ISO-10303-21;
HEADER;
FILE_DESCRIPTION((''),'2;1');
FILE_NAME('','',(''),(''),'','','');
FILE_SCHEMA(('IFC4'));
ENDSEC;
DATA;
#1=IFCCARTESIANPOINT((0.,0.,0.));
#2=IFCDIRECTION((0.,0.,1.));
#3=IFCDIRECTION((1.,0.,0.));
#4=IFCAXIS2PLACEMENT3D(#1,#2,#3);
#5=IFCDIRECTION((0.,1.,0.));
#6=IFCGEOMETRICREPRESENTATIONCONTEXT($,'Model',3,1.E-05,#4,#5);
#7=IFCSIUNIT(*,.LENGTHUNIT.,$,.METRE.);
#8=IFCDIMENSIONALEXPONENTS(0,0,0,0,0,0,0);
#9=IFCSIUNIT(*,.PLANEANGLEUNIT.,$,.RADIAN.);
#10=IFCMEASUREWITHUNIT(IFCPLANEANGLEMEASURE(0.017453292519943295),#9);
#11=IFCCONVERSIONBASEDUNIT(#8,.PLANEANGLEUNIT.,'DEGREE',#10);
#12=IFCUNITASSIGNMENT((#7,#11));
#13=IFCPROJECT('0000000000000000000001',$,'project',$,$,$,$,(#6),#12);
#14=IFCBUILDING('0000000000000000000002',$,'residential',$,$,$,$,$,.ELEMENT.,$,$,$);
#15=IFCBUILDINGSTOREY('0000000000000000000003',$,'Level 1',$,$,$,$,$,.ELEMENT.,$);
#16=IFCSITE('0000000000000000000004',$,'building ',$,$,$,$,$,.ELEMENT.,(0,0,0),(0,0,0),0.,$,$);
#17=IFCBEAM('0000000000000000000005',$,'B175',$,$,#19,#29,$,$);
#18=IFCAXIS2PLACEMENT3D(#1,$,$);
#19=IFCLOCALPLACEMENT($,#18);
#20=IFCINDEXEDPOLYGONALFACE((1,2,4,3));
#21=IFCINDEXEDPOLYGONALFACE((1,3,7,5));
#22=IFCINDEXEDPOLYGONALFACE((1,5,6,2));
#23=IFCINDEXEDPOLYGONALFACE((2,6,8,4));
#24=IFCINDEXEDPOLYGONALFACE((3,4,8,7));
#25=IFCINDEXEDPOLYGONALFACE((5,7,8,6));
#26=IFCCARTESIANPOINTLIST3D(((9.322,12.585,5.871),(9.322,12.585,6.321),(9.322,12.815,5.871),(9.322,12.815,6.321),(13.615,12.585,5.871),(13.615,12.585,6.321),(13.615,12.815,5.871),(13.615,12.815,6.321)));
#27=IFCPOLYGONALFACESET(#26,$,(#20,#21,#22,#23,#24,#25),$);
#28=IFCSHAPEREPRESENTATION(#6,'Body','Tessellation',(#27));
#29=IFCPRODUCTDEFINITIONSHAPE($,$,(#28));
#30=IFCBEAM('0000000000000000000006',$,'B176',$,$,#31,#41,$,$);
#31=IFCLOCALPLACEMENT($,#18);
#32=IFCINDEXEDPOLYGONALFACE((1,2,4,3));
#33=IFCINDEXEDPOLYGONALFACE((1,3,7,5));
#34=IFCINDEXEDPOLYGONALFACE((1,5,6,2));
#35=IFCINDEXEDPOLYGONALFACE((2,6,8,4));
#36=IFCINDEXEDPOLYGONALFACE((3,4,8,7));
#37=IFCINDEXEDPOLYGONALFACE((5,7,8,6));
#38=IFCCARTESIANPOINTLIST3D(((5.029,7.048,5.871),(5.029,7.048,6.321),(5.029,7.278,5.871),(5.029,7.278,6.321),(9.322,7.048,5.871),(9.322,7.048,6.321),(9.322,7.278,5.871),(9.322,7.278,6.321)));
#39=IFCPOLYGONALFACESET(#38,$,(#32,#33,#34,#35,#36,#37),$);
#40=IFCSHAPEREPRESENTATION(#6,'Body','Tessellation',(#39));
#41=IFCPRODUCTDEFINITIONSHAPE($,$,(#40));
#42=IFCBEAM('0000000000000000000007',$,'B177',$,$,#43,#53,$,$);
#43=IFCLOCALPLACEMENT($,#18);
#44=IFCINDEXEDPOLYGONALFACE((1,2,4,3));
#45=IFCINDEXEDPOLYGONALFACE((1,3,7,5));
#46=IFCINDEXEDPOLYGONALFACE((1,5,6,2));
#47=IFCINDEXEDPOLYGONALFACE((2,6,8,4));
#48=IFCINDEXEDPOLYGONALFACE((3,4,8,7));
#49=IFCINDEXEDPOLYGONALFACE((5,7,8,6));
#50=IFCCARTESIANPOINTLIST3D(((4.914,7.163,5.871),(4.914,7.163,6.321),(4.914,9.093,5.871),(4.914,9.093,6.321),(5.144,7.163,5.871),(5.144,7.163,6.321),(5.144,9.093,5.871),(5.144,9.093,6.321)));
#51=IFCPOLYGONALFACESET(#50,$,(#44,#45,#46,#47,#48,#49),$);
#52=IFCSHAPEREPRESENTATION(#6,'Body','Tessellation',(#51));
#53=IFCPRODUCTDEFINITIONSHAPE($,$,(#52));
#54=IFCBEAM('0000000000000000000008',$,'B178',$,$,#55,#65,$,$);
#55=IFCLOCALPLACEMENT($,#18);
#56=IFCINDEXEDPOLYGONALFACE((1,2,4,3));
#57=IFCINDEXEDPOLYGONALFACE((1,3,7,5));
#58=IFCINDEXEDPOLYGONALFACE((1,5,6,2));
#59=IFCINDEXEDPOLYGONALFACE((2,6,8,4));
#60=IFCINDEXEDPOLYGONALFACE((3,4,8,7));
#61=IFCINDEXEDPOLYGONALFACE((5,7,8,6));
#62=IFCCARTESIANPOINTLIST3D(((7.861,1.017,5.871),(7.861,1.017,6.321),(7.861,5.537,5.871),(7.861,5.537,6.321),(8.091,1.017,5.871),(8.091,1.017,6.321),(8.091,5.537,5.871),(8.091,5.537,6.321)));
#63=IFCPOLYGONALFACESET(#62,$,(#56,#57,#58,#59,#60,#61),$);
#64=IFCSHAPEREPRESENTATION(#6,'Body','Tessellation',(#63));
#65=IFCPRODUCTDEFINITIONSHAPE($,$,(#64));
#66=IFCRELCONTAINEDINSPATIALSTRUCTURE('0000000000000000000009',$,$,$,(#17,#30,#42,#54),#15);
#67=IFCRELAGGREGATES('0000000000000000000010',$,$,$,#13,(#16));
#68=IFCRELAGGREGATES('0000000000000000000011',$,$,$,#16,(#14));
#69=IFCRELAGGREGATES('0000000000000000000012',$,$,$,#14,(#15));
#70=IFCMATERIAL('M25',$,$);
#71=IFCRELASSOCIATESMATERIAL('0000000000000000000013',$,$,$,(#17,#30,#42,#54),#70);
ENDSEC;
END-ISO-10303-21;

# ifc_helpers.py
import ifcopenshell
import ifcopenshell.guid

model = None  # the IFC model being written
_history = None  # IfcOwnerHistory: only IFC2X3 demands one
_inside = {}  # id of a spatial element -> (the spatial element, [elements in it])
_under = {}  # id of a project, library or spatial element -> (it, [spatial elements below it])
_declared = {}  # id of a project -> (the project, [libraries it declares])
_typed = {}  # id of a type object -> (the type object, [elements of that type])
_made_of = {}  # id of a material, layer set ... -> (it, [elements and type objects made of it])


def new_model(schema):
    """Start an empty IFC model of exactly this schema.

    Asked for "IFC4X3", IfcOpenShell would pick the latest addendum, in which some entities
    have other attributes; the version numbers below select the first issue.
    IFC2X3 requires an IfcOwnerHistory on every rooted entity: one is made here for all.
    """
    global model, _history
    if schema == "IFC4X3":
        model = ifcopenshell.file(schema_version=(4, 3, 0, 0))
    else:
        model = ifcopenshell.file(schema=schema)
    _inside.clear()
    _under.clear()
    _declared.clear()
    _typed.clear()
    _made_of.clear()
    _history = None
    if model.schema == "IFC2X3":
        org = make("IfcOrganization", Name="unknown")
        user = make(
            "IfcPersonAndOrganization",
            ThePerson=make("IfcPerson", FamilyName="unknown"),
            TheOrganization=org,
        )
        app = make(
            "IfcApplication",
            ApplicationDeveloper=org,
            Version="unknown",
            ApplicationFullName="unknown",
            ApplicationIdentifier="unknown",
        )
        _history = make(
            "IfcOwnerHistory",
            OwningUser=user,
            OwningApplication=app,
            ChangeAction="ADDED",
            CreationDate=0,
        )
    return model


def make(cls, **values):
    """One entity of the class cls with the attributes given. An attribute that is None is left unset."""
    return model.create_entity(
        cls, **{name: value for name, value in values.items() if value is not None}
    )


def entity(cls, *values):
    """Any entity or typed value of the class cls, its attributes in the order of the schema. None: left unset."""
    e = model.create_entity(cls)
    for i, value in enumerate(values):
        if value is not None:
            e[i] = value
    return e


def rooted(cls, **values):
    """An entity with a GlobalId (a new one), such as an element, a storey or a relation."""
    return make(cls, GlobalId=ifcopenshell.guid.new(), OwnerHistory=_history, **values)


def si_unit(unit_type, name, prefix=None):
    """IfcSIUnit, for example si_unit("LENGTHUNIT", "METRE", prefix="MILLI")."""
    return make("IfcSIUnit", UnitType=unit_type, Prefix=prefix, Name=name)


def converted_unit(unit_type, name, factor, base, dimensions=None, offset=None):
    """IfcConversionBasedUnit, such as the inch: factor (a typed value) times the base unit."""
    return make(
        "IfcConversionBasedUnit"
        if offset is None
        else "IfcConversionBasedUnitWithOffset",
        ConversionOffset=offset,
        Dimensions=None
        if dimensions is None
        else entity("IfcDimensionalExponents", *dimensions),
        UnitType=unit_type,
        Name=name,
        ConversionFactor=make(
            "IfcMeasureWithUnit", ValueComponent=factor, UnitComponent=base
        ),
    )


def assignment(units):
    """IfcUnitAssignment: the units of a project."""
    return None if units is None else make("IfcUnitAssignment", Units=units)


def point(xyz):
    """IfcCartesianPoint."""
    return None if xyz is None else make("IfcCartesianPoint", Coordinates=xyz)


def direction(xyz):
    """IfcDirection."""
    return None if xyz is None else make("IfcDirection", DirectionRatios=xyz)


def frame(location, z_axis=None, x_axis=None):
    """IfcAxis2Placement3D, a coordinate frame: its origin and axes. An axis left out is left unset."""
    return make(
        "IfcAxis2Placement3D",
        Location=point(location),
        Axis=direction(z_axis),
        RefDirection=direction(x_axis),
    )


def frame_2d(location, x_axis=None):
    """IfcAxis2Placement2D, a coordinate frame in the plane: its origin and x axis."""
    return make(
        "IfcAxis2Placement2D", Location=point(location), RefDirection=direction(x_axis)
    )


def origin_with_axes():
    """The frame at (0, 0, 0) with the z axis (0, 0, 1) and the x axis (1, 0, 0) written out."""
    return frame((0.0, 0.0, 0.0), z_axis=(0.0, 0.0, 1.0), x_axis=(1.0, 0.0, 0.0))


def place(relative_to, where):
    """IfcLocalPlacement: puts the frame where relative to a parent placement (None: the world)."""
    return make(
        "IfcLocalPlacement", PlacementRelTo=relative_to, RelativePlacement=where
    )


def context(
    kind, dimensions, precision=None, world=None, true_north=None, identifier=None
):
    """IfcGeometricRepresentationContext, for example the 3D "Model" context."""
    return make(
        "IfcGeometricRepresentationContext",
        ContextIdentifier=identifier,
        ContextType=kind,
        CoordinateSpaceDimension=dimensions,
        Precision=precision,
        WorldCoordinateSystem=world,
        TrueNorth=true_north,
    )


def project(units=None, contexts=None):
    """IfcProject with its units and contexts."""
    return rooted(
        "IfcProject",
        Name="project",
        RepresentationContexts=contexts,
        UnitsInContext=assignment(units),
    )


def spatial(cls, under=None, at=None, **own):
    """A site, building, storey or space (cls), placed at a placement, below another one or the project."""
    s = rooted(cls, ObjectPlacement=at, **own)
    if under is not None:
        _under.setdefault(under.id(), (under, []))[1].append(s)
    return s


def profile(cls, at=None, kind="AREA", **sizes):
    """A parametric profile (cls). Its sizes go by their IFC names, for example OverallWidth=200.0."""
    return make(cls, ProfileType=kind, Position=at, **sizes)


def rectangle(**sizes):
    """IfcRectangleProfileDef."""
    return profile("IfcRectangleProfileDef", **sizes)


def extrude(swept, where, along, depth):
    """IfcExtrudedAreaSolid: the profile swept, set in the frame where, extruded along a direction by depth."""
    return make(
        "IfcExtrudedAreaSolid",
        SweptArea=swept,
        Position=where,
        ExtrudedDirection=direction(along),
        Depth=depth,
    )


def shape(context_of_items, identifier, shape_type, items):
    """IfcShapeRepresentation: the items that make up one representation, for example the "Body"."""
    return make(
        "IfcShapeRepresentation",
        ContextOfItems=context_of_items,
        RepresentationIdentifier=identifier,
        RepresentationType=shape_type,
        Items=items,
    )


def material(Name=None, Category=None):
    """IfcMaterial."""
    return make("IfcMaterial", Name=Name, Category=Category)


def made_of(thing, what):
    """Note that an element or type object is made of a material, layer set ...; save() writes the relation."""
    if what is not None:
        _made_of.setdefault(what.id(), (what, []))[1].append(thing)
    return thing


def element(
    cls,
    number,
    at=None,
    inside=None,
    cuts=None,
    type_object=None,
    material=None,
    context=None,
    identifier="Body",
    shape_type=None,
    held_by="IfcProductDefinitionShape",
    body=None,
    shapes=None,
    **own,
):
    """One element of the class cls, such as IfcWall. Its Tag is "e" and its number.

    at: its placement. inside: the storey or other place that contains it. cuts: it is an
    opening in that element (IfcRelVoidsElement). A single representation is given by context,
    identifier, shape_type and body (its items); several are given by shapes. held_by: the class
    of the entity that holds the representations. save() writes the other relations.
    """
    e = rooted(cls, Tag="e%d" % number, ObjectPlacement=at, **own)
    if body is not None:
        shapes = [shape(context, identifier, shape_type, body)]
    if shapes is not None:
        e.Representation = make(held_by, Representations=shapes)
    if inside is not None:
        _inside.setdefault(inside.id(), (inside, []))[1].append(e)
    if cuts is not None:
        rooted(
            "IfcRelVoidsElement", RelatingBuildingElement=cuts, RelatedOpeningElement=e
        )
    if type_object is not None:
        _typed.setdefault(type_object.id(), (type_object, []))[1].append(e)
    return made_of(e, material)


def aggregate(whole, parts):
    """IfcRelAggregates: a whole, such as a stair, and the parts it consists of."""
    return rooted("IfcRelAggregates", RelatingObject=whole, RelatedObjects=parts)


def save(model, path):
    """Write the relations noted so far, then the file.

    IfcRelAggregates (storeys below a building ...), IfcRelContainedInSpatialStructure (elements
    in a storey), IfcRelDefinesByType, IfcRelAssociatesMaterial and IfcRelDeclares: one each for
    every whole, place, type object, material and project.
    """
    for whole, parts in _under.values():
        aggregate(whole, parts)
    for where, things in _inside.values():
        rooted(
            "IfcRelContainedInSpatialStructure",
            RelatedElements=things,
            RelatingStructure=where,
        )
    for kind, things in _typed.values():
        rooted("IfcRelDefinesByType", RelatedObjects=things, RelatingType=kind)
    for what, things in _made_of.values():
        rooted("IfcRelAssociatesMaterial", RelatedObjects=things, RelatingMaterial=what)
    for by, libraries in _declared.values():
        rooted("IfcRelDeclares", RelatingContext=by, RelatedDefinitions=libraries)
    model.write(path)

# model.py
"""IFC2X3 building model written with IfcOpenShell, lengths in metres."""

from ifc_helpers import new_model, entity, si_unit, converted_unit, direction, frame, frame_2d, origin_with_axes, place, context, project, spatial, rectangle, extrude, material, element, save


model = new_model("IFC2X3")

# Units and contexts
model_context = context("Model", 3, precision=1e-05, world=origin_with_axes(), true_north=direction((0.0, 1.0, 0.0)))
ifc_project = project(units=[si_unit("LENGTHUNIT", "METRE"), converted_unit("PLANEANGLEUNIT", "DEGREE", entity("IfcPlaneAngleMeasure", 0.017453292519943295), si_unit("PLANEANGLEUNIT", "RADIAN"), dimensions=[0, 0, 0, 0, 0, 0, 0])], contexts=[model_context])

# Site, building, storey
site = spatial("IfcSite", under=ifc_project, Name="building ", CompositionType="ELEMENT", RefLatitude=(0, 0, 0), RefLongitude=(0, 0, 0), RefElevation=0.0)
building = spatial("IfcBuilding", under=site, Name="residential", CompositionType="ELEMENT")
storey = spatial("IfcBuildingStorey", under=building, Name="Level 1", CompositionType="ELEMENT")

# Beams
ifc_material = material(Name="M25")
placement = place(None, origin_with_axes())
element("IfcBeam", 1, at=placement, inside=storey, material=ifc_material, Name="B175", context=model_context, shape_type="SweptSolid", body=[
    extrude(rectangle(XDim=0.23, YDim=0.45, at=frame_2d((0.0, 0.0), x_axis=(0.0, 1.0, 0.0))), frame((9.322, 12.7, 6.096), z_axis=(1.0, 0.0, 0.0), x_axis=(0.0, 0.0, -1.0)), (0.0, 0.0, 1.0), 4.293),
])
element("IfcBeam", 2, at=placement, inside=storey, material=ifc_material, Name="B176", context=model_context, shape_type="SweptSolid", body=[
    extrude(rectangle(XDim=0.23, YDim=0.45, at=frame_2d((0.0, 0.0), x_axis=(0.0, 1.0, 0.0))), frame((5.029, 7.163, 6.096), z_axis=(1.0, 0.0, 0.0), x_axis=(0.0, 0.0, -1.0)), (0.0, 0.0, 1.0), 4.293),
])
element("IfcBeam", 3, at=placement, inside=storey, material=ifc_material, Name="B177", context=model_context, shape_type="SweptSolid", body=[
    extrude(rectangle(XDim=0.23, YDim=0.45, at=frame_2d((0.0, 0.0), x_axis=(0.0, 1.0, 0.0))), frame((5.029, 9.093, 6.096), z_axis=(0.0, -1.0, 0.0), x_axis=(0.0, 0.0, -1.0)), (0.0, 0.0, 1.0), 1.93),
])
element("IfcBeam", 4, at=placement, inside=storey, material=ifc_material, Name="B178", context=model_context, shape_type="SweptSolid", body=[
    extrude(rectangle(XDim=0.23, YDim=0.45, at=frame_2d((0.0, 0.0), x_axis=(0.0, 1.0, 0.0))), frame((7.976, 1.017, 6.096), z_axis=(0.0, 1.0, 0.0), x_axis=(0.0, 0.0, -1.0)), (0.0, 0.0, 1.0), 4.52),
])

save(model, "model.ifc")
